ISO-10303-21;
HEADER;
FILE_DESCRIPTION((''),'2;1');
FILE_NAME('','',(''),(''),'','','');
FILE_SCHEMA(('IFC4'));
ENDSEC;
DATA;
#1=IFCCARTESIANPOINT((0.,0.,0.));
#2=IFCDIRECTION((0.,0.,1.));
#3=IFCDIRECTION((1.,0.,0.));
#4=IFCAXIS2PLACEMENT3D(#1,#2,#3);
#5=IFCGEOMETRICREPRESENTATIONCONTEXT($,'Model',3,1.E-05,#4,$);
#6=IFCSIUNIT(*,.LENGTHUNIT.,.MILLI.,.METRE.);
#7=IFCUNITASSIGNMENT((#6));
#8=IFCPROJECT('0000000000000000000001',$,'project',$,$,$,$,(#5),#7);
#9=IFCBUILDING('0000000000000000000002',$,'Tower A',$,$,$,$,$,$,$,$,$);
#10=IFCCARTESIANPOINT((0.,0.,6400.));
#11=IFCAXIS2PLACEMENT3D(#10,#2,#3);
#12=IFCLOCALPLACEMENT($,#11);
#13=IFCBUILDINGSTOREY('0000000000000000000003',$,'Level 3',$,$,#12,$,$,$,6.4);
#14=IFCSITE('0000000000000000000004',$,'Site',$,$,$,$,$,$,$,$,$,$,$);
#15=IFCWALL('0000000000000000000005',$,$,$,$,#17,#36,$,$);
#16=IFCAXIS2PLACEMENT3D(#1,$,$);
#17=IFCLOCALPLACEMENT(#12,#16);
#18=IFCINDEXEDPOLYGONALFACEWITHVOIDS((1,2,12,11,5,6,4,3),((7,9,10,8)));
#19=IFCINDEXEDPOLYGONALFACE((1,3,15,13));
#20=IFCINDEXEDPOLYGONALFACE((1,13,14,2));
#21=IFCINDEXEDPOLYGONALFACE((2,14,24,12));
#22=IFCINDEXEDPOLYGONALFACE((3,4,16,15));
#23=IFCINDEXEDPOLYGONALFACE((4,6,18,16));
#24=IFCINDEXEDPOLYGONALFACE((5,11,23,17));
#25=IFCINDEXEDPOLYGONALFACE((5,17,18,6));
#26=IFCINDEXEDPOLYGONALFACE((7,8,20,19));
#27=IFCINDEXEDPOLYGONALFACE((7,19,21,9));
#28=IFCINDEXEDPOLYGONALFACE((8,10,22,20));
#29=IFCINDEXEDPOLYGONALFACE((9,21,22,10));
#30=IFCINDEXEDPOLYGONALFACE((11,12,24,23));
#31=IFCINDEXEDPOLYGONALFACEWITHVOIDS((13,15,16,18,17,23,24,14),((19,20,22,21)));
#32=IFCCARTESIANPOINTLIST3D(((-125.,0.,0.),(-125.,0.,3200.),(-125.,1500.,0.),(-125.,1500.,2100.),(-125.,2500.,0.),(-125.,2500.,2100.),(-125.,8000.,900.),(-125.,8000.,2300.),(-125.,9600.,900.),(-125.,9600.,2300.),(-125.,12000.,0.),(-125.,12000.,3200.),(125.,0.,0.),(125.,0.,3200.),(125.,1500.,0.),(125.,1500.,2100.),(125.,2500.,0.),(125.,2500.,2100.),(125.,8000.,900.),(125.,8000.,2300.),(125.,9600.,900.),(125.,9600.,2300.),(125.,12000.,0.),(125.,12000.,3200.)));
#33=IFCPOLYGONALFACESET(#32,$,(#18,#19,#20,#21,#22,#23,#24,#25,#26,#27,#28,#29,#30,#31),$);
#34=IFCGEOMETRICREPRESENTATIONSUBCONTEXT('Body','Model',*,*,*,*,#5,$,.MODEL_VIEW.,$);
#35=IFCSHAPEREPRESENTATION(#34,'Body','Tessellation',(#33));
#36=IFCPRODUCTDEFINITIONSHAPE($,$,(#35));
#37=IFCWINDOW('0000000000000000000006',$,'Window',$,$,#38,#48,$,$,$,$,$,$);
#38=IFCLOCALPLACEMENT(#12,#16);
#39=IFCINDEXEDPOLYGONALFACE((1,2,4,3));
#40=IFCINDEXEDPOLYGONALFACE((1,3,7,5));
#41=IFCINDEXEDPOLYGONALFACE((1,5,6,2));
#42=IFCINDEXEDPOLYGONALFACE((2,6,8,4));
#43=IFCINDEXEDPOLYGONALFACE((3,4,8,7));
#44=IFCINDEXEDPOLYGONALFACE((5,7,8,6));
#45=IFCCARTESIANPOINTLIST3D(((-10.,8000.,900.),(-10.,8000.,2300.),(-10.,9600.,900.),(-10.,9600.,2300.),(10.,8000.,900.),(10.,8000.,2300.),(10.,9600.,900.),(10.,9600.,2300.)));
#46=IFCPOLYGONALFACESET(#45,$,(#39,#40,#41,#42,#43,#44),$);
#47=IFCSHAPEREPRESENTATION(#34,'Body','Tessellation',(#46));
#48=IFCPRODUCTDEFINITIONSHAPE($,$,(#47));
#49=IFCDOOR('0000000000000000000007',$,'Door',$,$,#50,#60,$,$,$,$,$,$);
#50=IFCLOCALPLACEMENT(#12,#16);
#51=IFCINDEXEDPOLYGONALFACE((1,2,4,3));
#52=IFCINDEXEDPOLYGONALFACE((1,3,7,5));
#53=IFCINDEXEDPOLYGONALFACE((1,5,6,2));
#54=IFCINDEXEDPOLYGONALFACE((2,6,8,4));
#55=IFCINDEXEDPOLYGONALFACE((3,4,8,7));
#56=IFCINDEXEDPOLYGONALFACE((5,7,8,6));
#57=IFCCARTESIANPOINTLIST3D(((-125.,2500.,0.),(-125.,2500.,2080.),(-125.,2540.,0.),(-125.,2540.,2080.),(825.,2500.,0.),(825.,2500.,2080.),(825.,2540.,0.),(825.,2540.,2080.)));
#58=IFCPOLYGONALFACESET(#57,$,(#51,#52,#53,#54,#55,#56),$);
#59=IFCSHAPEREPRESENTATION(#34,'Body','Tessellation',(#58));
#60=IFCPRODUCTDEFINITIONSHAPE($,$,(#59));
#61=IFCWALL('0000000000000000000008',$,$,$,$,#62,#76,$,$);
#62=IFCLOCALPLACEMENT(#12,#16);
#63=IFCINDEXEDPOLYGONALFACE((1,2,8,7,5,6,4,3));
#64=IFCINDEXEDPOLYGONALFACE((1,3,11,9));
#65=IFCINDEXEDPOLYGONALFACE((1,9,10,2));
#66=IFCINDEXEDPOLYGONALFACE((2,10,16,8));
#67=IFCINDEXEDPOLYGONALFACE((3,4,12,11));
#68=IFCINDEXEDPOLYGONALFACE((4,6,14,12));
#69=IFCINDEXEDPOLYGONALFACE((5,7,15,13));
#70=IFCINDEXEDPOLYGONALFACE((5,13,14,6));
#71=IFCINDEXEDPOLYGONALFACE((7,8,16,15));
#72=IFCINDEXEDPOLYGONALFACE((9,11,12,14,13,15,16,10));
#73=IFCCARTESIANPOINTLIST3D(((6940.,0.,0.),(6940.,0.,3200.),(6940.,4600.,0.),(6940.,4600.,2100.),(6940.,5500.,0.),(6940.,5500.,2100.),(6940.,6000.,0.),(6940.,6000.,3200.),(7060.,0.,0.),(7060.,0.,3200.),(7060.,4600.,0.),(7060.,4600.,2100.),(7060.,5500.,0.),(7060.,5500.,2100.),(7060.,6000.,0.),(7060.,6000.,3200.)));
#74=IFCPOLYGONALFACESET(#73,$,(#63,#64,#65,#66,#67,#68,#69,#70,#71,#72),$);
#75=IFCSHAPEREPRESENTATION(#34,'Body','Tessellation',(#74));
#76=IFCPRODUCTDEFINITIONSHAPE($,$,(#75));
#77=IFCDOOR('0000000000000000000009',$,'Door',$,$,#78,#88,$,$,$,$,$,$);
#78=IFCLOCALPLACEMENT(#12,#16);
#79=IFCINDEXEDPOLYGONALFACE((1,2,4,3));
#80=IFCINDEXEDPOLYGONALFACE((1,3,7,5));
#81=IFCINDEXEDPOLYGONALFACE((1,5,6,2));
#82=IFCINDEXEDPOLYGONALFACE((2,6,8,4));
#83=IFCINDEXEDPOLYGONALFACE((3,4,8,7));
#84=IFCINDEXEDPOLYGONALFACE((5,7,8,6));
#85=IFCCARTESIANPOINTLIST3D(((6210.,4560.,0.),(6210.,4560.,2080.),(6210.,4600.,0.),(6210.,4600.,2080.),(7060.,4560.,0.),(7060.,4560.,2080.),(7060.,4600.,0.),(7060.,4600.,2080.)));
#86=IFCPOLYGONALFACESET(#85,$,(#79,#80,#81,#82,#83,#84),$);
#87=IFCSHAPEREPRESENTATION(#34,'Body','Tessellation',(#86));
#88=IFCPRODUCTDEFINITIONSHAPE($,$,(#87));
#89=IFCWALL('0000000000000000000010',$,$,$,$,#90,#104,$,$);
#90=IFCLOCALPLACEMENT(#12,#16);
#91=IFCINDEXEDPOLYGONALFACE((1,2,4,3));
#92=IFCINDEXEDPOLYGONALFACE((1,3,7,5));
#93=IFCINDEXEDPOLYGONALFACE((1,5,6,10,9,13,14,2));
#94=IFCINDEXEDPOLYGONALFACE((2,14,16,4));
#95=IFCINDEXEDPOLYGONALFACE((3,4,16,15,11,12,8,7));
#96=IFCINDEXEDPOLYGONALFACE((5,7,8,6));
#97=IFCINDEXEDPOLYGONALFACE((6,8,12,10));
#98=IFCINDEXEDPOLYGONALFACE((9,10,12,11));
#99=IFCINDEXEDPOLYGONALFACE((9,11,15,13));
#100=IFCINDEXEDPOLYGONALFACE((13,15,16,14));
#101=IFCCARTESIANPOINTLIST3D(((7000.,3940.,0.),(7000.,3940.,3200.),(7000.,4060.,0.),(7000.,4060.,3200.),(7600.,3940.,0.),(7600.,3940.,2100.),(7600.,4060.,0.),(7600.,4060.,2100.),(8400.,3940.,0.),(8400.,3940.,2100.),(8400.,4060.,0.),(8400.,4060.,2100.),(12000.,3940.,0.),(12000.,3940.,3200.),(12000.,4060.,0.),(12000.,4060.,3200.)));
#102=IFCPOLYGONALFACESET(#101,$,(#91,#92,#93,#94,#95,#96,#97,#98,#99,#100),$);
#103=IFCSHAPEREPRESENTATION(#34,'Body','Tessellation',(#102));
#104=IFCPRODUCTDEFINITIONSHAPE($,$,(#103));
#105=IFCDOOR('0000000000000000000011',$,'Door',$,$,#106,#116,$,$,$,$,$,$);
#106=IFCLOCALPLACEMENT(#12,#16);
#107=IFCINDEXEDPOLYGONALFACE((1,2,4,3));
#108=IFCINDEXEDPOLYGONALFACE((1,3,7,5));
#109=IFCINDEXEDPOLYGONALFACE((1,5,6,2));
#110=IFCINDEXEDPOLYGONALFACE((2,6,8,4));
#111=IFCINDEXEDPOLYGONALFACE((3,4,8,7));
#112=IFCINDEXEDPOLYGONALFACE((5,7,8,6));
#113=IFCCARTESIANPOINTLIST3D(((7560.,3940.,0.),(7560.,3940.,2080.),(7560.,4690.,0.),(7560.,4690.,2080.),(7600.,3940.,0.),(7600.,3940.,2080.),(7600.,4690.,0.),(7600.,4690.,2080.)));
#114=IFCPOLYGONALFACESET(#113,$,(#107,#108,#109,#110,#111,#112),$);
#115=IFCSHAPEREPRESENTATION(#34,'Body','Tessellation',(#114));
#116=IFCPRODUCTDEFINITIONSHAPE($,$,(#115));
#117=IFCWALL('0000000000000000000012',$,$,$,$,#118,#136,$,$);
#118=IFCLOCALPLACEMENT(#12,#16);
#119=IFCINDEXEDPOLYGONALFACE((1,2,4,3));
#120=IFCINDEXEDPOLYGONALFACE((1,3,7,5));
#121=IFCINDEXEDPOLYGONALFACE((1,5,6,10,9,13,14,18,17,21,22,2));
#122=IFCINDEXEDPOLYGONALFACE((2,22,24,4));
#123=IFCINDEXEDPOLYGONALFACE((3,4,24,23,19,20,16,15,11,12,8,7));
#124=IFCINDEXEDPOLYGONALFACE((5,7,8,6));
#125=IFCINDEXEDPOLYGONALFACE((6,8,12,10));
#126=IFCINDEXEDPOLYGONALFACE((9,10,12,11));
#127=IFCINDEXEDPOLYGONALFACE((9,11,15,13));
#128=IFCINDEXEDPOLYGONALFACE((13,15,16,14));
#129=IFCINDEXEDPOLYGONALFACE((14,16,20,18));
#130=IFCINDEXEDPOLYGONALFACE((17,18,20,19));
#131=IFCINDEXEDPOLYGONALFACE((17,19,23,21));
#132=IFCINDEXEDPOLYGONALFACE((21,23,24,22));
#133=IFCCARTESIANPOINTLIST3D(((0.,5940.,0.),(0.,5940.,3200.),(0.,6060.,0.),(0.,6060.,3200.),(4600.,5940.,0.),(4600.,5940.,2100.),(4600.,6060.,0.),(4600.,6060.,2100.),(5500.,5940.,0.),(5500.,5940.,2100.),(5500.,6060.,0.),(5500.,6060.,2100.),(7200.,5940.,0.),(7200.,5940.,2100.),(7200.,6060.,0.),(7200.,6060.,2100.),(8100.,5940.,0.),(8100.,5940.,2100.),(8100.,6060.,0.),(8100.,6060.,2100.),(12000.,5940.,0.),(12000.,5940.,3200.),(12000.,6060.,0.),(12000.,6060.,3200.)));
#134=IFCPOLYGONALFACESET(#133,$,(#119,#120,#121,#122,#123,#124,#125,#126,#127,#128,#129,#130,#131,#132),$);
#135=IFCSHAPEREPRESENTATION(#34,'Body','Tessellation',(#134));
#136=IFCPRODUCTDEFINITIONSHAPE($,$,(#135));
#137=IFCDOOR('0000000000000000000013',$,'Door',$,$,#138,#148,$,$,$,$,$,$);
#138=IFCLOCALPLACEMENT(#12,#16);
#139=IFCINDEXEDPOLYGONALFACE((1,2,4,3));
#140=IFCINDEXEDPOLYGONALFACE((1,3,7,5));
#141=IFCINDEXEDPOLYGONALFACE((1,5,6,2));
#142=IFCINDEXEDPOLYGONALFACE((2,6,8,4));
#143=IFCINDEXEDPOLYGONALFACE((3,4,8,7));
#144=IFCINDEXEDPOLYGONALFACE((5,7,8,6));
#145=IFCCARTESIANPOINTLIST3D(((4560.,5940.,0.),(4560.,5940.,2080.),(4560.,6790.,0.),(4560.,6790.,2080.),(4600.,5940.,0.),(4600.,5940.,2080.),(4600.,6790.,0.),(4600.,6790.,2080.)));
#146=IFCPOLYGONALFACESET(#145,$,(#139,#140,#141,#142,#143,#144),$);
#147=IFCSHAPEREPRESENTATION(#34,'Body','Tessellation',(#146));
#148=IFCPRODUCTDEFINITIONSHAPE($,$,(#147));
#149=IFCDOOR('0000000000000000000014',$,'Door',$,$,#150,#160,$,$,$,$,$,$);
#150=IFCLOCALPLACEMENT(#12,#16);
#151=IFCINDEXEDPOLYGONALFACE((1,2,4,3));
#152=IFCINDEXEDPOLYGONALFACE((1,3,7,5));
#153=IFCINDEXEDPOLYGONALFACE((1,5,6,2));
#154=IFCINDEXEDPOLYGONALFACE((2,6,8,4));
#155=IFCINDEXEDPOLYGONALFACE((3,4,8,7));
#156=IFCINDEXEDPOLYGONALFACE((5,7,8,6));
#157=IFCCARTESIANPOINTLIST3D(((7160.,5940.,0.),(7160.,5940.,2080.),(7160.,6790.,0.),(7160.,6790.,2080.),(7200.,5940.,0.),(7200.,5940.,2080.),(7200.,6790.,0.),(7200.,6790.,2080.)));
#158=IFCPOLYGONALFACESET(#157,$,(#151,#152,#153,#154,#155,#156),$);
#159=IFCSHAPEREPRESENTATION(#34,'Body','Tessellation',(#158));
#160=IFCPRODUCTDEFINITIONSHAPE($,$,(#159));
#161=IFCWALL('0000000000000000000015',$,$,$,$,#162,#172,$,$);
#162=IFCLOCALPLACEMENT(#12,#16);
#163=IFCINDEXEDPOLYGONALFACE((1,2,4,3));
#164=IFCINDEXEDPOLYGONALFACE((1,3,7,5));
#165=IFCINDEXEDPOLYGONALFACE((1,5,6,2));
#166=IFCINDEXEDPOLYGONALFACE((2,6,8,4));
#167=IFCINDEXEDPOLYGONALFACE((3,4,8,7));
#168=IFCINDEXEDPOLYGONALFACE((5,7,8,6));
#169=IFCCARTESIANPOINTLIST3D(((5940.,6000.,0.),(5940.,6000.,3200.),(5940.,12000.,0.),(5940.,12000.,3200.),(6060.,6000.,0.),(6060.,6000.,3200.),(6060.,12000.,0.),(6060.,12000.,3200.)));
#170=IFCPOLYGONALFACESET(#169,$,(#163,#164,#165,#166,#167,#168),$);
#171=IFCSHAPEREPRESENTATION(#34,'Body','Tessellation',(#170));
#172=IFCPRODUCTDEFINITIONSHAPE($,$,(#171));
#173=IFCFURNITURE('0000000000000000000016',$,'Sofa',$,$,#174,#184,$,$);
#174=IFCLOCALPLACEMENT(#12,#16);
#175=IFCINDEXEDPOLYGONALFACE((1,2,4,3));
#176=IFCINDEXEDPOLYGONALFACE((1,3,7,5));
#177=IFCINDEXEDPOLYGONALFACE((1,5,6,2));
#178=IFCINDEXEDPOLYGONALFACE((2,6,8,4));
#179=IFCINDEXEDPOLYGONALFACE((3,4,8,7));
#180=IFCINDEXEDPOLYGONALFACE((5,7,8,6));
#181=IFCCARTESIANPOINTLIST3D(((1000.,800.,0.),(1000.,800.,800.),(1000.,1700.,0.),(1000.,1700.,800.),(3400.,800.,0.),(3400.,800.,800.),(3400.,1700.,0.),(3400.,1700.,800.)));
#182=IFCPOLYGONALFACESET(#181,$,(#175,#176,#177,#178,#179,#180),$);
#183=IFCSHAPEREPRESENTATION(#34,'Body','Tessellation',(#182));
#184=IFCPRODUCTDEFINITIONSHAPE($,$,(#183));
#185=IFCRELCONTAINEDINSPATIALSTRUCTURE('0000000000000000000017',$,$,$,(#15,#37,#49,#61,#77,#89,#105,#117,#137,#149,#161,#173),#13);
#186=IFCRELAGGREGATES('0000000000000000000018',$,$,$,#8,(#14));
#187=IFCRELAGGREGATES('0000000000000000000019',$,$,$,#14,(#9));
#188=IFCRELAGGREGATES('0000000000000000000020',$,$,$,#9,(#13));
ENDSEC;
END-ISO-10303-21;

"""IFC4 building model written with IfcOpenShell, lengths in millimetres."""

from ifc_helpers import new_model, si_unit, frame, origin_with_axes, place, context, subcontext, project, spatial, indexed_curve, outline, extrude, element, fill, save


model = new_model("IFC4")

# Units and contexts
model_context = context("Model", 3, precision=1e-05, world=origin_with_axes())
body_context = subcontext(model_context, "Body", "Model", "MODEL_VIEW")
ifc_project = project(units=[si_unit("LENGTHUNIT", "METRE", prefix="MILLI")], contexts=[model_context])

# Site, building, storey
site = spatial("IfcSite", under=ifc_project, Name="Site")
building = spatial("IfcBuilding", under=site, Name="Tower A")
storey_placement = place(None, frame((0.0, 0.0, 6400.0), z_axis=(0.0, 0.0, 1.0), x_axis=(1.0, 0.0, 0.0)))
storey = spatial("IfcBuildingStorey", under=building, at=storey_placement, Name="Level 3", Elevation=6.4)

# Wall, openings, window, door
wall_1_placement = place(storey_placement, frame((-125.0, 12000.0, 0.0), z_axis=(0.0, 0.0, 1.0), x_axis=(0.0, -1.0, 0.0)))
wall_1 = element("IfcWall", 1, at=wall_1_placement, inside=storey, context=body_context, shape_type="SweptSolid", body=[
    extrude(outline(indexed_curve([(0.0, 0.0), (0.0, 250.0), (12000.0, 250.0), (12000.0, 0.0), (0.0, 0.0)], self_intersect=False)), origin_with_axes(), (0.0, 0.0, 1.0), 3200.0),
])
opening_1_placement = place(wall_1_placement, frame((2400.0, 0.0, 900.0), z_axis=(0.0, 0.0, 1.0), x_axis=(1.0, 0.0, 0.0)))
opening_1 = element("IfcOpeningElement", 2, at=opening_1_placement, cuts=wall_1, context=body_context, shape_type="SweptSolid", body=[
    extrude(outline(indexed_curve([(0.0, 0.0), (0.0, 250.0), (1600.0, 250.0), (1600.0, 0.0), (0.0, 0.0)], self_intersect=False)), origin_with_axes(), (0.0, 0.0, 1.0), 1400.0),
])
opening_2_placement = place(wall_1_placement, frame((9500.0, 0.0, 0.0), z_axis=(0.0, 0.0, 1.0), x_axis=(1.0, 0.0, 0.0)))
opening_2 = element("IfcOpeningElement", 3, at=opening_2_placement, cuts=wall_1, context=body_context, shape_type="SweptSolid", body=[
    extrude(outline(indexed_curve([(0.0, 0.0), (0.0, 250.0), (1000.0, 250.0), (1000.0, 0.0), (0.0, 0.0)], self_intersect=False)), origin_with_axes(), (0.0, 0.0, 1.0), 2100.0),
])
window_1_placement = place(storey_placement, frame((-10.0, 9600.0, 900.0), z_axis=(0.0, 0.0, 1.0), x_axis=(0.0, -1.0, 0.0)))
window_1 = element("IfcWindow", 4, at=window_1_placement, inside=storey, Name="Window", context=body_context, shape_type="SweptSolid", body=[
    extrude(outline(indexed_curve([(0.0, 0.0), (0.0, 20.0), (1600.0, 20.0), (1600.0, 0.0), (0.0, 0.0)], self_intersect=False)), origin_with_axes(), (0.0, 0.0, 1.0), 1400.0),
])
fill(opening_1, window_1)
door_1_placement = place(storey_placement, frame((-125.0, 2500.0, 0.0), z_axis=(0.0, 0.0, 1.0), x_axis=(1.0, 0.0, 0.0)))
door_1 = element("IfcDoor", 5, at=door_1_placement, inside=storey, Name="Door", context=body_context, shape_type="SweptSolid", body=[
    extrude(outline(indexed_curve([(0.0, 0.0), (0.0, 40.0), (950.0, 40.0), (950.0, 0.0), (0.0, 0.0)], self_intersect=False)), origin_with_axes(), (0.0, 0.0, 1.0), 2080.0),
])
fill(opening_2, door_1)

# Walls, openings, doors
wall_2_placement = place(storey_placement, frame((7060.0, 0.0, 0.0), z_axis=(0.0, 0.0, 1.0), x_axis=(0.0, 1.0, 0.0)))
wall_2 = element("IfcWall", 6, at=wall_2_placement, inside=storey, context=body_context, shape_type="SweptSolid", body=[
    extrude(outline(indexed_curve([(0.0, 0.0), (0.0, 120.0), (6000.0, 120.0), (6000.0, 0.0), (0.0, 0.0)], self_intersect=False)), origin_with_axes(), (0.0, 0.0, 1.0), 3200.0),
])
opening_3_placement = place(wall_2_placement, frame((4600.0, 0.0, 0.0), z_axis=(0.0, 0.0, 1.0), x_axis=(1.0, 0.0, 0.0)))
opening_3 = element("IfcOpeningElement", 7, at=opening_3_placement, cuts=wall_2, context=body_context, shape_type="SweptSolid", body=[
    extrude(outline(indexed_curve([(0.0, 0.0), (0.0, 120.0), (900.0, 120.0), (900.0, 0.0), (0.0, 0.0)], self_intersect=False)), origin_with_axes(), (0.0, 0.0, 1.0), 2100.0),
])
door_2_placement = place(storey_placement, frame((7060.0, 4600.0, 0.0), z_axis=(0.0, 0.0, 1.0), x_axis=(-1.0, 0.0, 0.0)))
door_2 = element("IfcDoor", 8, at=door_2_placement, inside=storey, Name="Door", context=body_context, shape_type="SweptSolid", body=[
    extrude(outline(indexed_curve([(0.0, 0.0), (0.0, 40.0), (850.0, 40.0), (850.0, 0.0), (0.0, 0.0)], self_intersect=False)), origin_with_axes(), (0.0, 0.0, 1.0), 2080.0),
])
fill(opening_3, door_2)
wall_3_placement = place(storey_placement, frame((7000.0, 3940.0, 0.0), z_axis=(0.0, 0.0, 1.0), x_axis=(1.0, 0.0, 0.0)))
wall_3 = element("IfcWall", 9, at=wall_3_placement, inside=storey, context=body_context, shape_type="SweptSolid", body=[
    extrude(outline(indexed_curve([(0.0, 0.0), (0.0, 120.0), (5000.0, 120.0), (5000.0, 0.0), (0.0, 0.0)], self_intersect=False)), origin_with_axes(), (0.0, 0.0, 1.0), 3200.0),
])
opening_4_placement = place(wall_3_placement, frame((600.0, 0.0, 0.0), z_axis=(0.0, 0.0, 1.0), x_axis=(1.0, 0.0, 0.0)))
opening_4 = element("IfcOpeningElement", 10, at=opening_4_placement, cuts=wall_3, context=body_context, shape_type="SweptSolid", body=[
    extrude(outline(indexed_curve([(0.0, 0.0), (0.0, 120.0), (800.0, 120.0), (800.0, 0.0), (0.0, 0.0)], self_intersect=False)), origin_with_axes(), (0.0, 0.0, 1.0), 2100.0),
])
door_3_placement = place(storey_placement, frame((7600.0, 3940.0, 0.0), z_axis=(0.0, 0.0, 1.0), x_axis=(0.0, 1.0, 0.0)))
door_3 = element("IfcDoor", 11, at=door_3_placement, inside=storey, Name="Door", context=body_context, shape_type="SweptSolid", body=[
    extrude(outline(indexed_curve([(0.0, 0.0), (0.0, 40.0), (750.0, 40.0), (750.0, 0.0), (0.0, 0.0)], self_intersect=False)), origin_with_axes(), (0.0, 0.0, 1.0), 2080.0),
])
fill(opening_4, door_3)

# Wall, openings, doors
wall_4_placement = place(storey_placement, frame((0.0, 5940.0, 0.0), z_axis=(0.0, 0.0, 1.0), x_axis=(1.0, 0.0, 0.0)))
wall_4 = element("IfcWall", 12, at=wall_4_placement, inside=storey, context=body_context, shape_type="SweptSolid", body=[
    extrude(outline(indexed_curve([(0.0, 0.0), (0.0, 120.0), (12000.0, 120.0), (12000.0, 0.0), (0.0, 0.0)], self_intersect=False)), origin_with_axes(), (0.0, 0.0, 1.0), 3200.0),
])
opening_5_placement = place(wall_4_placement, frame((4600.0, 0.0, 0.0), z_axis=(0.0, 0.0, 1.0), x_axis=(1.0, 0.0, 0.0)))
opening_5 = element("IfcOpeningElement", 13, at=opening_5_placement, cuts=wall_4, context=body_context, shape_type="SweptSolid", body=[
    extrude(outline(indexed_curve([(0.0, 0.0), (0.0, 120.0), (900.0, 120.0), (900.0, 0.0), (0.0, 0.0)], self_intersect=False)), origin_with_axes(), (0.0, 0.0, 1.0), 2100.0),
])
opening_6_placement = place(wall_4_placement, frame((7200.0, 0.0, 0.0), z_axis=(0.0, 0.0, 1.0), x_axis=(1.0, 0.0, 0.0)))
opening_6 = element("IfcOpeningElement", 14, at=opening_6_placement, cuts=wall_4, context=body_context, shape_type="SweptSolid", body=[
    extrude(outline(indexed_curve([(0.0, 0.0), (0.0, 120.0), (900.0, 120.0), (900.0, 0.0), (0.0, 0.0)], self_intersect=False)), origin_with_axes(), (0.0, 0.0, 1.0), 2100.0),
])
door_4_placement = place(storey_placement, frame((4600.0, 5940.0, 0.0), z_axis=(0.0, 0.0, 1.0), x_axis=(0.0, 1.0, 0.0)))
door_4 = element("IfcDoor", 15, at=door_4_placement, inside=storey, Name="Door", context=body_context, shape_type="SweptSolid", body=[
    extrude(outline(indexed_curve([(0.0, 0.0), (0.0, 40.0), (850.0, 40.0), (850.0, 0.0), (0.0, 0.0)], self_intersect=False)), origin_with_axes(), (0.0, 0.0, 1.0), 2080.0),
])
fill(opening_5, door_4)
door_5_placement = place(storey_placement, frame((7200.0, 5940.0, 0.0), z_axis=(0.0, 0.0, 1.0), x_axis=(0.0, 1.0, 0.0)))
door_5 = element("IfcDoor", 16, at=door_5_placement, inside=storey, Name="Door", context=body_context, shape_type="SweptSolid", body=[
    extrude(outline(indexed_curve([(0.0, 0.0), (0.0, 40.0), (850.0, 40.0), (850.0, 0.0), (0.0, 0.0)], self_intersect=False)), origin_with_axes(), (0.0, 0.0, 1.0), 2080.0),
])
fill(opening_6, door_5)

# Wall
wall_5_placement = place(storey_placement, frame((6060.0, 6000.0, 0.0), z_axis=(0.0, 0.0, 1.0), x_axis=(0.0, 1.0, 0.0)))
element("IfcWall", 17, at=wall_5_placement, inside=storey, context=body_context, shape_type="SweptSolid", body=[
    extrude(outline(indexed_curve([(0.0, 0.0), (0.0, 120.0), (6000.0, 120.0), (6000.0, 0.0), (0.0, 0.0)], self_intersect=False)), origin_with_axes(), (0.0, 0.0, 1.0), 3200.0),
])

# Furniture
furniture_1_placement = place(storey_placement, frame((1000.0, 800.0, 0.0), z_axis=(0.0, 0.0, 1.0), x_axis=(1.0, 0.0, 0.0)))
element("IfcFurniture", 18, at=furniture_1_placement, inside=storey, Name="Sofa", context=body_context, shape_type="SweptSolid", body=[
    extrude(outline(indexed_curve([(0.0, 0.0), (2400.0, 0.0), (2400.0, 900.0), (0.0, 900.0)])), None, (0.0, 0.0, 1.0), 800.0),
])

save(model, "model.ifc")
